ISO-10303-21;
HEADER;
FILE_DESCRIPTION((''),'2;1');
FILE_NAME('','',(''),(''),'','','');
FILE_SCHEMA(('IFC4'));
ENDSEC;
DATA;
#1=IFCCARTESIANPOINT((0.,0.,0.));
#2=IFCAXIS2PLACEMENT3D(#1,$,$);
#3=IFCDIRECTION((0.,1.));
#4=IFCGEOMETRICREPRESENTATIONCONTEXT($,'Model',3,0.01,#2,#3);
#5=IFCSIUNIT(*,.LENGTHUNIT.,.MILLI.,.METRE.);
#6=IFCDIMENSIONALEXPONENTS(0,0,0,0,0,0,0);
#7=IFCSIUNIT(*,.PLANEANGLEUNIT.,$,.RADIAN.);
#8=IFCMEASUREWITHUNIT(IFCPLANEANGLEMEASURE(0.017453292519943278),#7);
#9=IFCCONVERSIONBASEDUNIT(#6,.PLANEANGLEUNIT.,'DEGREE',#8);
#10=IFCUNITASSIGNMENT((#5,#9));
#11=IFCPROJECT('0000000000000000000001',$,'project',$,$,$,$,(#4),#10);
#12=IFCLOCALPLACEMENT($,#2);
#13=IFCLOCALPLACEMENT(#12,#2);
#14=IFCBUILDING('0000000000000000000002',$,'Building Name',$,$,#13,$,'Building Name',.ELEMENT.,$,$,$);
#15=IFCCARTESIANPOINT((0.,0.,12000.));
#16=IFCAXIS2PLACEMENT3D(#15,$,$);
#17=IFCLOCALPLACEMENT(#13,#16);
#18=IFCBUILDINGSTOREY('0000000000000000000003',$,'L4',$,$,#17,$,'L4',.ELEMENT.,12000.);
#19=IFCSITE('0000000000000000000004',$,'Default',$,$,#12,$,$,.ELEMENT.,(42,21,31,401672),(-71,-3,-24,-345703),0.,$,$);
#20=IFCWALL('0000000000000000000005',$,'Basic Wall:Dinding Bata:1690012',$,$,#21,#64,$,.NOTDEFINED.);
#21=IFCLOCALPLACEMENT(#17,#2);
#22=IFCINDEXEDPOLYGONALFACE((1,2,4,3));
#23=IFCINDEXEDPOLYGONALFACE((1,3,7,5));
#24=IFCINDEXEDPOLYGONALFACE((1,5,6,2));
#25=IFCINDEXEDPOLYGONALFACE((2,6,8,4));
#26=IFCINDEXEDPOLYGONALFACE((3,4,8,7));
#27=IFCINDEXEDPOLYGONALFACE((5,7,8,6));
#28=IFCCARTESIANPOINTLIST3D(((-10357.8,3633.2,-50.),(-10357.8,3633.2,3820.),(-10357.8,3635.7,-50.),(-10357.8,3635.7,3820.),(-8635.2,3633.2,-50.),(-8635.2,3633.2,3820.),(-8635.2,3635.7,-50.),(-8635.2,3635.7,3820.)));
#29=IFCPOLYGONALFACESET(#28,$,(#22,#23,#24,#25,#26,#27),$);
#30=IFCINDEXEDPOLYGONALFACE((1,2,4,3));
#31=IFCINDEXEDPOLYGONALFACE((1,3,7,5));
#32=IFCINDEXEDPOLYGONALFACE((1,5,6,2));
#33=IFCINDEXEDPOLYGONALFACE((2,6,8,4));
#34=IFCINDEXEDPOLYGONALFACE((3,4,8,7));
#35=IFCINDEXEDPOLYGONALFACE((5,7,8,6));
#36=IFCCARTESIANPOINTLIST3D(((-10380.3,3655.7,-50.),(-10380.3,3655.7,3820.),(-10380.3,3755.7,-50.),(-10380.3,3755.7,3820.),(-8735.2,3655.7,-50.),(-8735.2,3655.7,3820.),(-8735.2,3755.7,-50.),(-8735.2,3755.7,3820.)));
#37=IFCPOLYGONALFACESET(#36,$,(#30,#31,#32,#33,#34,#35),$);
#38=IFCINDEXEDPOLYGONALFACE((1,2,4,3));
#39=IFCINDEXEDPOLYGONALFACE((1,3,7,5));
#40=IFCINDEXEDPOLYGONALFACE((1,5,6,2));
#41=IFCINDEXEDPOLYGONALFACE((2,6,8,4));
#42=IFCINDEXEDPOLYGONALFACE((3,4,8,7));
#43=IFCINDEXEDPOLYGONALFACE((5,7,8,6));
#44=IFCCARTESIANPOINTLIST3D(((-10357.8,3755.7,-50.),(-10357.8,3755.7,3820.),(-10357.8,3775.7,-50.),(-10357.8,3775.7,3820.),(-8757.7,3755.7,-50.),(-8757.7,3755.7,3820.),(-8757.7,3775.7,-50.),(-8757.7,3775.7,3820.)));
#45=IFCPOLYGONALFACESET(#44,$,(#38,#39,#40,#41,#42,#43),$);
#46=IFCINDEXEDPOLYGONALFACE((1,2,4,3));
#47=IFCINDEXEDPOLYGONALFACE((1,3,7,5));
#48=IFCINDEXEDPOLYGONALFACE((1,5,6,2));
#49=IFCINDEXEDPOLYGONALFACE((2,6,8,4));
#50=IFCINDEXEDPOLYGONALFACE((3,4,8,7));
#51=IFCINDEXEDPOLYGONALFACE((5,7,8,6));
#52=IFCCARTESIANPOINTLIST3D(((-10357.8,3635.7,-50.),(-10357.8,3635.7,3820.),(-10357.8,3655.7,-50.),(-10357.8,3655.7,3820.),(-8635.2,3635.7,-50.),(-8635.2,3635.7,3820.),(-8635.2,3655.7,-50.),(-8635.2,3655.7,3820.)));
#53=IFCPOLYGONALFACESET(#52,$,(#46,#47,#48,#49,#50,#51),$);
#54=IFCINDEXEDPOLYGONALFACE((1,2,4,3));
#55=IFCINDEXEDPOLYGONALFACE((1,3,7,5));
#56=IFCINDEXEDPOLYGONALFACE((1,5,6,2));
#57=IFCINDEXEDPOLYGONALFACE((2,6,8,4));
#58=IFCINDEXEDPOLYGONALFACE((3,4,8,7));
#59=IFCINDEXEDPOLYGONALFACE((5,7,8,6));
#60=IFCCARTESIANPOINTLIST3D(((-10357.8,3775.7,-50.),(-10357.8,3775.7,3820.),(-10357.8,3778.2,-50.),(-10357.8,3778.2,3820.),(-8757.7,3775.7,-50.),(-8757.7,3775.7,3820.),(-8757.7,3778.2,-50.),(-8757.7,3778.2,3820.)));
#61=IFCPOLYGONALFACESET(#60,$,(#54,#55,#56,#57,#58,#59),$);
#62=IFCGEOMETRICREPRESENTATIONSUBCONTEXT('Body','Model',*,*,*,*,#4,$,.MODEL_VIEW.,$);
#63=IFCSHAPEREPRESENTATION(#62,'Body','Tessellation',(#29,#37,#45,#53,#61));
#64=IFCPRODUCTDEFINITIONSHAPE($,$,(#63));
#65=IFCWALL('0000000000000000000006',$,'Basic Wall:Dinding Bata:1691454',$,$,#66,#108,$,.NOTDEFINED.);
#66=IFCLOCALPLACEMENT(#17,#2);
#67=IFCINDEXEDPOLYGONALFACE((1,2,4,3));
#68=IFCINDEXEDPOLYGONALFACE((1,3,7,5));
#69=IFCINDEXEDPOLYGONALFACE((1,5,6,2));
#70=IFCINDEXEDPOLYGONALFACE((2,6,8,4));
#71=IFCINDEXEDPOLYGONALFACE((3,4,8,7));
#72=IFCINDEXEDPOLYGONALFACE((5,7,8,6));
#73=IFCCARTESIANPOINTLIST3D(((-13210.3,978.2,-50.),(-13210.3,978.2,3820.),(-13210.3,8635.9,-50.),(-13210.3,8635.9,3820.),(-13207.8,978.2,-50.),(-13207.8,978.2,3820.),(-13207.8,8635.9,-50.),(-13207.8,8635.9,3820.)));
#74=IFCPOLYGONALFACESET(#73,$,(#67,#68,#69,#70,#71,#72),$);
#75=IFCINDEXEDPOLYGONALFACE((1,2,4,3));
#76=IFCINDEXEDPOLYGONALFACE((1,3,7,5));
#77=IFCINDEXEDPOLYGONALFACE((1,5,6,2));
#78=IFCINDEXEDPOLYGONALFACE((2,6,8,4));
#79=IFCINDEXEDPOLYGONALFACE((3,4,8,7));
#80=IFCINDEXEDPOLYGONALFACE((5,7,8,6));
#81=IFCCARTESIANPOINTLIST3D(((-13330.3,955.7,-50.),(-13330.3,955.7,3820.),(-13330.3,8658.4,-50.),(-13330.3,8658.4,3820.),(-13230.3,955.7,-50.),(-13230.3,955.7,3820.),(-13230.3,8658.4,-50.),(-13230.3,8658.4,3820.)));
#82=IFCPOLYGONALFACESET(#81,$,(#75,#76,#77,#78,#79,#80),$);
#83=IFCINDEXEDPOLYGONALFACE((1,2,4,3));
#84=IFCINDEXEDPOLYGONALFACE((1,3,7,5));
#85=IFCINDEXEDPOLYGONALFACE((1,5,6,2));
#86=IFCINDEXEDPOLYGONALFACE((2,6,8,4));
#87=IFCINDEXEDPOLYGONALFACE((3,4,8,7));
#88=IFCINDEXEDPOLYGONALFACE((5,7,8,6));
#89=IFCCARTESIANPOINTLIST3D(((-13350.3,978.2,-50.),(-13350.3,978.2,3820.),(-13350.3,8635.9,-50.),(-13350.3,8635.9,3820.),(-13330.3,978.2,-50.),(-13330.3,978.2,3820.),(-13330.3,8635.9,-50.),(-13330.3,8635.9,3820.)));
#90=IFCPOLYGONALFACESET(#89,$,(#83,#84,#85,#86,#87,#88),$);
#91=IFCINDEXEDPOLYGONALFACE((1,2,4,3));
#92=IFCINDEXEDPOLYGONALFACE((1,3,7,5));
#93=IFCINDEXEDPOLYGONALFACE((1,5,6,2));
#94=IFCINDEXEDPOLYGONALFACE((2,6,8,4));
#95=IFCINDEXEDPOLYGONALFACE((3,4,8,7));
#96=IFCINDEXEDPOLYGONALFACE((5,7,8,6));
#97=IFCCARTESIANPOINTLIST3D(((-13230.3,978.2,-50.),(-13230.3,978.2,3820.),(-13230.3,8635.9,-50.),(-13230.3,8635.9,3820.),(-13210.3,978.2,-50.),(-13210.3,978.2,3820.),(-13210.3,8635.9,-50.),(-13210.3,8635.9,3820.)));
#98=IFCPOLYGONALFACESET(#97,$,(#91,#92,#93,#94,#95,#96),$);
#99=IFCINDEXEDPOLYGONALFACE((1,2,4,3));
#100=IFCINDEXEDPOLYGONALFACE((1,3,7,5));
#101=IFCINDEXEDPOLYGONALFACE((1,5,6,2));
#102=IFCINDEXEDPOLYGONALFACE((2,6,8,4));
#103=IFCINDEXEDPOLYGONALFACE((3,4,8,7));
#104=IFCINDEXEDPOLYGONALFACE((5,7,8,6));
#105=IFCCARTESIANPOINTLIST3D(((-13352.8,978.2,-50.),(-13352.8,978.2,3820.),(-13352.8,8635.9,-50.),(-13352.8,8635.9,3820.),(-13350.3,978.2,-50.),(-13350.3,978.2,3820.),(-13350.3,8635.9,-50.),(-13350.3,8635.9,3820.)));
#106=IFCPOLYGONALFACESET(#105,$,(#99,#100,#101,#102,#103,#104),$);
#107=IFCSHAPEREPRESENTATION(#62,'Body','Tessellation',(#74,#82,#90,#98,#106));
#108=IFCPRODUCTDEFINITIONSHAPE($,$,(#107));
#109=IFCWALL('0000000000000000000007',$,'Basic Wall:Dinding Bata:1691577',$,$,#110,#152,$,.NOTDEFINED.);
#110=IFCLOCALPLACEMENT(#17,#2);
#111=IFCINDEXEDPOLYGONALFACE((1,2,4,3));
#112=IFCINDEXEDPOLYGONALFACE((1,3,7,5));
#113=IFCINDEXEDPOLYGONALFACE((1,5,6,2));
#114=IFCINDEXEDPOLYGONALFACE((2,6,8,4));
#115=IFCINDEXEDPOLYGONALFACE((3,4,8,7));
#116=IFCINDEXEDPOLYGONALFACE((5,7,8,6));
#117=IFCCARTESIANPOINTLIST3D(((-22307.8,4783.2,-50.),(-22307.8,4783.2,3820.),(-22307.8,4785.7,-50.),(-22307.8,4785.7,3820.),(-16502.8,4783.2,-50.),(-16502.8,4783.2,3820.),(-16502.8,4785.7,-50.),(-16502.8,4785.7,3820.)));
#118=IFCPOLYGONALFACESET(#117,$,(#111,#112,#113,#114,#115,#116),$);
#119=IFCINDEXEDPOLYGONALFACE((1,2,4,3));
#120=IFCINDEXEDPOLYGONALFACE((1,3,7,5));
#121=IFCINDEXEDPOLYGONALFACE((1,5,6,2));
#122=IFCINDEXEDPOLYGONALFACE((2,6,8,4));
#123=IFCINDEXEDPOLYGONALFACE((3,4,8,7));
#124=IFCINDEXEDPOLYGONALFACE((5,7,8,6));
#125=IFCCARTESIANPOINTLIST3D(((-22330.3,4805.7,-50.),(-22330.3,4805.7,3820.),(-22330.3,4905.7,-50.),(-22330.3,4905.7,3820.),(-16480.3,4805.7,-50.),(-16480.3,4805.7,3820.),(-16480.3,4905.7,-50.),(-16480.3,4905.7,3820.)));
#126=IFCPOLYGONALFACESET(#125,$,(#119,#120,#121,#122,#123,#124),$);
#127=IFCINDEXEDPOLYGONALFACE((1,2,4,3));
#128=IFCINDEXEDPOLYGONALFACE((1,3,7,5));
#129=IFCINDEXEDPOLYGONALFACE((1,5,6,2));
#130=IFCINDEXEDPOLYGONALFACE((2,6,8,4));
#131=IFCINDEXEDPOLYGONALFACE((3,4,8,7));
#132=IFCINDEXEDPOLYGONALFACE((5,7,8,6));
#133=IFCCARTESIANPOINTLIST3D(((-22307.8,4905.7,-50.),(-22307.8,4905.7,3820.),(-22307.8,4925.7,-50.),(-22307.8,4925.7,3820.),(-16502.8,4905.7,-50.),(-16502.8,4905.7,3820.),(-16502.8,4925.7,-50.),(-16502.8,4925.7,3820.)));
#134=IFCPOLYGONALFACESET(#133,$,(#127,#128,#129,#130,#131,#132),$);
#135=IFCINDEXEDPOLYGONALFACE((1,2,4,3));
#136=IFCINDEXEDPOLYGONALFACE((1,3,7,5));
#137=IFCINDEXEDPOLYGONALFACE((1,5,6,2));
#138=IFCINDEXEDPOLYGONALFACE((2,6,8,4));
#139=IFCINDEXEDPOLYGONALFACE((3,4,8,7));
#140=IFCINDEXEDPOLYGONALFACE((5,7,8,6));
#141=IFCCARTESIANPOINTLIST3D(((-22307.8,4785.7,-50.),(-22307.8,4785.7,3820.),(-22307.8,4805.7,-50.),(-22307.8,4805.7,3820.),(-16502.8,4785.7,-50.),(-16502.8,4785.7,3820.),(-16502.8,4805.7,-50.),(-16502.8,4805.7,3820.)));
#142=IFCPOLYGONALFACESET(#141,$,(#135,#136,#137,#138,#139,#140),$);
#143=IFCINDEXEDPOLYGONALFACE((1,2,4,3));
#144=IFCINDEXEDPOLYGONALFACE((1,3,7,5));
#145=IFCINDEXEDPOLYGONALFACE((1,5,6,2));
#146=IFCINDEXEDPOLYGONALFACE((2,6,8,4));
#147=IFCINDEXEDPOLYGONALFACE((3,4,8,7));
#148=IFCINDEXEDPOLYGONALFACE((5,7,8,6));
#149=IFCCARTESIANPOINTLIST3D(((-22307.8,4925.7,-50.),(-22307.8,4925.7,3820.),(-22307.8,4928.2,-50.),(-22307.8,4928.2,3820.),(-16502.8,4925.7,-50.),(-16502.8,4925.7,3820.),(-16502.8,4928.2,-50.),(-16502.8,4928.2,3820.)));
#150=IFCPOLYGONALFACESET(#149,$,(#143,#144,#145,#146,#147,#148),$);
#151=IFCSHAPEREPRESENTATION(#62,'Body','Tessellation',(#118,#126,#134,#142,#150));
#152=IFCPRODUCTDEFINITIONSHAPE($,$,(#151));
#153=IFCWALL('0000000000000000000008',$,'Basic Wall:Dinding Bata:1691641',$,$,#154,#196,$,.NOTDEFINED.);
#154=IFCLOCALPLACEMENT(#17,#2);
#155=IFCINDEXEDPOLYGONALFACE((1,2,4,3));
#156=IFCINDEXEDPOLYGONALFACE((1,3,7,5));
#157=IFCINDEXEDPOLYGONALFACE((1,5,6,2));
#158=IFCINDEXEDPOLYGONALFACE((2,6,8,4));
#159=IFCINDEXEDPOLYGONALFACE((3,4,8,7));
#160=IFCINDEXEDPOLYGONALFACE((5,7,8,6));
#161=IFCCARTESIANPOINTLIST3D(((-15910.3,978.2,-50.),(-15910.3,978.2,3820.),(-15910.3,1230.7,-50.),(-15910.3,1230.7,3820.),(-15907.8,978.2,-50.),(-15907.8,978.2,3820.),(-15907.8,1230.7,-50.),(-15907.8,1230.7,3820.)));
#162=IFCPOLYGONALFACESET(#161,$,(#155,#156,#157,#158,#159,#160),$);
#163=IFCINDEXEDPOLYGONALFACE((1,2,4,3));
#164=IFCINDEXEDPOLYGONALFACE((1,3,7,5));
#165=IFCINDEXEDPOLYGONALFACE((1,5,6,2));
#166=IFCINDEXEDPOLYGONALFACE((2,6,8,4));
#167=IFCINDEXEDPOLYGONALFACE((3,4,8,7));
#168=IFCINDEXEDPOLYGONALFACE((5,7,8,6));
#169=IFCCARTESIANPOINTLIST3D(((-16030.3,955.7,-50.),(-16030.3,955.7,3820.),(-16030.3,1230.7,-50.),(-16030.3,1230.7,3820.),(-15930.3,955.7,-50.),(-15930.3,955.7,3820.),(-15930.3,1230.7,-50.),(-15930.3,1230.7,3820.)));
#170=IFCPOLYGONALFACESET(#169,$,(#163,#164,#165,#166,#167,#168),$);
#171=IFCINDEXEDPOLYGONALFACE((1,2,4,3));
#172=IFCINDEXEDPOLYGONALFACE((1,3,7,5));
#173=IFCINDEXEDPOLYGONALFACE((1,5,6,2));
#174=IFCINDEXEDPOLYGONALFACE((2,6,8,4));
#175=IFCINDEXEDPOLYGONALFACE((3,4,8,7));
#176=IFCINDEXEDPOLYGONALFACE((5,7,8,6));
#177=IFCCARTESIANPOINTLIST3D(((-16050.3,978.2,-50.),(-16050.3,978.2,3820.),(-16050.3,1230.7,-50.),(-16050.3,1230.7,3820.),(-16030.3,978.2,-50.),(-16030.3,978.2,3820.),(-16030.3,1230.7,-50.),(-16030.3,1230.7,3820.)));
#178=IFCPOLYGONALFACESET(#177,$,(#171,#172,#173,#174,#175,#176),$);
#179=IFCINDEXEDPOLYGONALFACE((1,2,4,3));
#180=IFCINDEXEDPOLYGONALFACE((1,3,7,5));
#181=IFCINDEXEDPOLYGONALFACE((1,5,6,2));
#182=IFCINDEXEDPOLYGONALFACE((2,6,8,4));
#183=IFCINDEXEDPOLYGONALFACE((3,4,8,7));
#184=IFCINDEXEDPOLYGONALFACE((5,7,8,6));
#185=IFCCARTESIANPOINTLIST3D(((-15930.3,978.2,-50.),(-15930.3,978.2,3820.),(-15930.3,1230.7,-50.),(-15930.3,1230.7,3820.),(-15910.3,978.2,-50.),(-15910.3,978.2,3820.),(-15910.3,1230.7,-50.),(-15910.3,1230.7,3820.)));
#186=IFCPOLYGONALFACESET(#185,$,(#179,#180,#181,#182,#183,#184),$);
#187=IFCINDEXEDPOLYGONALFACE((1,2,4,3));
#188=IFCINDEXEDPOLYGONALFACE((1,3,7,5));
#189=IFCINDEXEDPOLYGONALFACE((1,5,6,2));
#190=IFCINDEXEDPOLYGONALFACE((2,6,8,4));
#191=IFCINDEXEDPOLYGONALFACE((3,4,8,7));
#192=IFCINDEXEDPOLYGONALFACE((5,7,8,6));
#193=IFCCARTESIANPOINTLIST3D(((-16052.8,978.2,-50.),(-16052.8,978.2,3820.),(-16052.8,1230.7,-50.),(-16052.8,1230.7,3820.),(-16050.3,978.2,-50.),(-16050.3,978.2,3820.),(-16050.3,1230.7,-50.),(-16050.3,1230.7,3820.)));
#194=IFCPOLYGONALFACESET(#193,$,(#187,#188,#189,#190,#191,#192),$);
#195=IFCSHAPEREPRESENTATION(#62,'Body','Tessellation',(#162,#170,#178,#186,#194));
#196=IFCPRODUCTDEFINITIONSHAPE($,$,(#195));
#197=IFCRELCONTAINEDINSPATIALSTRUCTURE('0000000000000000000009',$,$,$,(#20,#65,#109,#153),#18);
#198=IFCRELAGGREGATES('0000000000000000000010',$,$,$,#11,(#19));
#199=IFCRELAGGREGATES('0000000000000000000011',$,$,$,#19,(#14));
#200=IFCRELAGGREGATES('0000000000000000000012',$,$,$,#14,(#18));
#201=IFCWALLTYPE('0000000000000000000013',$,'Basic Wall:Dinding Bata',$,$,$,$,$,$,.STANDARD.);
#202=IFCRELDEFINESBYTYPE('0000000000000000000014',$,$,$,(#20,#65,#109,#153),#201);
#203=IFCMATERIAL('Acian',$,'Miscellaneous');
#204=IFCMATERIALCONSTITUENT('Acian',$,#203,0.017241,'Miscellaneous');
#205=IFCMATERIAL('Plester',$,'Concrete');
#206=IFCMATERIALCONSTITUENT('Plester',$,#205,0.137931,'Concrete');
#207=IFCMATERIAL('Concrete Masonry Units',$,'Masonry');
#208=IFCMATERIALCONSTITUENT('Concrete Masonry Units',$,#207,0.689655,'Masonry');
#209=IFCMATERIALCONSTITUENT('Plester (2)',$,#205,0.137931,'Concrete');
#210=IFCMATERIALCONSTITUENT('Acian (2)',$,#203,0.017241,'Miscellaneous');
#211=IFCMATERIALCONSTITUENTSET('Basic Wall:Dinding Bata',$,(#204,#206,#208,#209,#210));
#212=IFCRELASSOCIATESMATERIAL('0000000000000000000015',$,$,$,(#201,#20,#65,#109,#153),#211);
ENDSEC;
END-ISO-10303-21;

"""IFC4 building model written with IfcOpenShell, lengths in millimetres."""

from ifc_helpers import new_model, entity, si_unit, converted_unit, direction, frame, origin, place, context, subcontext, project, spatial, indexed_curve, outline, extrude, material, constituent, constituent_set, type_object, element, save


model = new_model("IFC4")

# Units and contexts
model_context = context("Model", 3, precision=0.01, world=origin(), true_north=direction((0.0, 1.0)))
body_context = subcontext(model_context, "Body", "Model", "MODEL_VIEW")
ifc_project = project(units=[si_unit("LENGTHUNIT", "METRE", prefix="MILLI"), converted_unit("PLANEANGLEUNIT", "DEGREE", entity("IfcPlaneAngleMeasure", 0.017453292519943278), si_unit("PLANEANGLEUNIT", "RADIAN"), dimensions=[0, 0, 0, 0, 0, 0, 0])], contexts=[model_context])

# Site, building, storey
site_placement = place(None, origin())
site = spatial("IfcSite", under=ifc_project, at=site_placement, Name="Default", CompositionType="ELEMENT", RefLatitude=(42, 21, 31, 401672), RefLongitude=(-71, -3, -24, -345703), RefElevation=0.0)
building_placement = place(site_placement, origin())
building = spatial("IfcBuilding", under=site, at=building_placement, Name="Building Name", LongName="Building Name", CompositionType="ELEMENT")
storey_placement = place(building_placement, frame((0.0, 0.0, 12000.0)))
storey = spatial("IfcBuildingStorey", under=building, at=storey_placement, Name="L4", LongName="L4", CompositionType="ELEMENT", Elevation=12000.0)

# Walls
ifc_material_1 = material(Name="Acian", Category="Miscellaneous")
ifc_constituent_1 = constituent(ifc_material_1, Name="Acian", Category="Miscellaneous", fraction=0.017241)
ifc_material_2 = material(Name="Plester", Category="Concrete")
ifc_constituent_2 = constituent(ifc_material_2, Name="Plester", Category="Concrete", fraction=0.137931)
ifc_material_3 = material(Name="Concrete Masonry Units", Category="Masonry")
ifc_constituent_3 = constituent(ifc_material_3, Name="Concrete Masonry Units", Category="Masonry", fraction=0.689655)
ifc_constituent_4 = constituent(ifc_material_2, Name="Plester (2)", Category="Concrete", fraction=0.137931)
ifc_constituent_5 = constituent(ifc_material_1, Name="Acian (2)", Category="Miscellaneous", fraction=0.017241)
ifc_constituent_set = constituent_set(constituents=[ifc_constituent_1, ifc_constituent_2, ifc_constituent_3, ifc_constituent_4, ifc_constituent_5], Name="Basic Wall:Dinding Bata")
wall_type = type_object("IfcWallType", Name="Basic Wall:Dinding Bata", PredefinedType="STANDARD", material=ifc_constituent_set)
wall_1_placement = place(storey_placement, frame((-8757.7, 3705.7, -50.0), z_axis=(0.0, 0.0, 1.0), x_axis=(-1.0, 0.0, 0.0)))
element("IfcWall", 1, at=wall_1_placement, inside=storey, type_object=wall_type, material=ifc_constituent_set, Name="Basic Wall:Dinding Bata:1690012", PredefinedType="NOTDEFINED", context=body_context, shape_type="SweptSolid", body=[
    extrude(outline(indexed_curve([(-1.3, -861.3), (1.2, -861.3), (1.3, 861.3), (-1.2, 861.3), (-1.3, -861.3)], self_intersect=False)), frame((738.8, 71.2, 0.0), z_axis=(0.0, 0.0, 1.0), x_axis=(0.0, -1.0, 0.0)), (0.0, 0.0, 1.0), 3870.0),
    extrude(outline(indexed_curve([(-822.5, -50.0), (822.5, -50.0), (822.5, 50.0), (-822.5, 50.0), (-822.5, -50.0)], self_intersect=False)), frame((800.0, 0.0, 0.0)), (0.0, 0.0, 1.0), 3870.0),
    extrude(outline(indexed_curve([(-800.0, -10.0), (800.0, -10.0), (800.0, 10.0), (-800.0, 10.0), (-800.0, -10.0)], self_intersect=False)), frame((800.0, -60.0, 0.0)), (0.0, 0.0, 1.0), 3870.0),
    extrude(outline(indexed_curve([(-861.3, -10.0), (861.3, -10.0), (861.3, 10.0), (-861.3, 10.0), (-861.3, -10.0)], self_intersect=False)), frame((738.8, 60.0, 0.0)), (0.0, 0.0, 1.0), 3870.0),
    extrude(outline(indexed_curve([(-1.3, -800.0), (1.2, -800.0), (1.3, 800.0), (-1.2, 800.0), (-1.3, -800.0)], self_intersect=False)), frame((800.0, -71.3, 0.0), z_axis=(0.0, 0.0, 1.0), x_axis=(0.0, 1.0, 0.0)), (0.0, 0.0, 1.0), 3870.0),
])
wall_2_placement = place(storey_placement, frame((-13280.3, 8635.9, -50.0), z_axis=(0.0, 0.0, 1.0), x_axis=(0.0, -1.0, 0.0)))
element("IfcWall", 2, at=wall_2_placement, inside=storey, type_object=wall_type, material=ifc_constituent_set, Name="Basic Wall:Dinding Bata:1691454", PredefinedType="NOTDEFINED", context=body_context, shape_type="SweptSolid", body=[
    extrude(outline(indexed_curve([(-1.3, -3828.8), (1.2, -3828.8), (1.3, 3828.8), (-1.2, 3828.8), (-1.3, -3828.8)], self_intersect=False)), frame((3828.8, 71.3, 0.0), z_axis=(0.0, 0.0, 1.0), x_axis=(0.0, -1.0, 0.0)), (0.0, 0.0, 1.0), 3870.0),
    extrude(outline(indexed_curve([(-3851.3, -50.0), (3851.3, -50.0), (3851.3, 50.0), (-3851.3, 50.0), (-3851.3, -50.0)], self_intersect=False)), frame((3828.8, 0.0, 0.0)), (0.0, 0.0, 1.0), 3870.0),
    extrude(outline(indexed_curve([(-3828.8, -10.0), (3828.8, -10.0), (3828.8, 10.0), (-3828.8, 10.0), (-3828.8, -10.0)], self_intersect=False)), frame((3828.8, -60.0, 0.0)), (0.0, 0.0, 1.0), 3870.0),
    extrude(outline(indexed_curve([(-3828.8, -10.0), (3828.8, -10.0), (3828.8, 10.0), (-3828.8, 10.0), (-3828.8, -10.0)], self_intersect=False)), frame((3828.8, 60.0, 0.0)), (0.0, 0.0, 1.0), 3870.0),
    extrude(outline(indexed_curve([(-1.3, -3828.8), (1.2, -3828.8), (1.3, 3828.8), (-1.2, 3828.8), (-1.3, -3828.8)], self_intersect=False)), frame((3828.8, -71.2, 0.0), z_axis=(0.0, 0.0, 1.0), x_axis=(0.0, 1.0, 0.0)), (0.0, 0.0, 1.0), 3870.0),
])
wall_3_placement = place(storey_placement, frame((-16502.8, 4855.7, -50.0), z_axis=(0.0, 0.0, 1.0), x_axis=(-1.0, 0.0, 0.0)))
element("IfcWall", 3, at=wall_3_placement, inside=storey, type_object=wall_type, material=ifc_constituent_set, Name="Basic Wall:Dinding Bata:1691577", PredefinedType="NOTDEFINED", context=body_context, shape_type="SweptSolid", body=[
    extrude(outline(indexed_curve([(-1.3, -2902.5), (1.2, -2902.5), (1.3, 2902.5), (-1.2, 2902.5), (-1.3, -2902.5)], self_intersect=False)), frame((2902.5, 71.2, 0.0), z_axis=(0.0, 0.0, 1.0), x_axis=(0.0, -1.0, 0.0)), (0.0, 0.0, 1.0), 3870.0),
    extrude(outline(indexed_curve([(-2925.0, -50.0), (2925.0, -50.0), (2925.0, 50.0), (-2925.0, 50.0), (-2925.0, -50.0)], self_intersect=False)), frame((2902.5, 0.0, 0.0)), (0.0, 0.0, 1.0), 3870.0),
    extrude(outline(indexed_curve([(-2902.5, -10.0), (2902.5, -10.0), (2902.5, 10.0), (-2902.5, 10.0), (-2902.5, -10.0)], self_intersect=False)), frame((2902.5, -60.0, 0.0)), (0.0, 0.0, 1.0), 3870.0),
    extrude(outline(indexed_curve([(-2902.5, -10.0), (2902.5, -10.0), (2902.5, 10.0), (-2902.5, 10.0), (-2902.5, -10.0)], self_intersect=False)), frame((2902.5, 60.0, 0.0)), (0.0, 0.0, 1.0), 3870.0),
    extrude(outline(indexed_curve([(-1.3, -2902.5), (1.2, -2902.5), (1.3, 2902.5), (-1.2, 2902.5), (-1.3, -2902.5)], self_intersect=False)), frame((2902.5, -71.3, 0.0), z_axis=(0.0, 0.0, 1.0), x_axis=(0.0, 1.0, 0.0)), (0.0, 0.0, 1.0), 3870.0),
])
wall_4_placement = place(storey_placement, frame((-15980.3, 1230.7, -50.0), z_axis=(0.0, 0.0, 1.0), x_axis=(0.0, -1.0, 0.0)))
element("IfcWall", 4, at=wall_4_placement, inside=storey, type_object=wall_type, material=ifc_constituent_set, Name="Basic Wall:Dinding Bata:1691641", PredefinedType="NOTDEFINED", context=body_context, shape_type="SweptSolid", body=[
    extrude(outline(indexed_curve([(-1.2, -126.2), (1.3, -126.2), (1.3, 126.2), (-1.2, 126.2), (-1.2, -126.2)], self_intersect=False)), frame((126.2, 71.3, 0.0), z_axis=(0.0, 0.0, 1.0), x_axis=(0.0, -1.0, 0.0)), (0.0, 0.0, 1.0), 3870.0),
    extrude(outline(indexed_curve([(-137.5, -50.0), (137.5, -50.0), (137.5, 50.0), (-137.5, 50.0), (-137.5, -50.0)], self_intersect=False)), frame((137.5, 0.0, 0.0)), (0.0, 0.0, 1.0), 3870.0),
    extrude(outline(indexed_curve([(-126.2, -10.0), (126.2, -10.0), (126.2, 10.0), (-126.2, 10.0), (-126.2, -10.0)], self_intersect=False)), frame((126.2, -60.0, 0.0)), (0.0, 0.0, 1.0), 3870.0),
    extrude(outline(indexed_curve([(-126.2, -10.0), (126.2, -10.0), (126.2, 10.0), (-126.2, 10.0), (-126.2, -10.0)], self_intersect=False)), frame((126.2, 60.0, 0.0)), (0.0, 0.0, 1.0), 3870.0),
    extrude(outline(indexed_curve([(-1.2, -126.2), (1.2, -126.2), (1.2, 126.2), (-1.2, 126.2), (-1.2, -126.2)], self_intersect=False)), frame((126.2, -71.2, 0.0), z_axis=(0.0, 0.0, 1.0), x_axis=(0.0, 1.0, 0.0)), (0.0, 0.0, 1.0), 3870.0),
])

save(model, "model.ifc")
